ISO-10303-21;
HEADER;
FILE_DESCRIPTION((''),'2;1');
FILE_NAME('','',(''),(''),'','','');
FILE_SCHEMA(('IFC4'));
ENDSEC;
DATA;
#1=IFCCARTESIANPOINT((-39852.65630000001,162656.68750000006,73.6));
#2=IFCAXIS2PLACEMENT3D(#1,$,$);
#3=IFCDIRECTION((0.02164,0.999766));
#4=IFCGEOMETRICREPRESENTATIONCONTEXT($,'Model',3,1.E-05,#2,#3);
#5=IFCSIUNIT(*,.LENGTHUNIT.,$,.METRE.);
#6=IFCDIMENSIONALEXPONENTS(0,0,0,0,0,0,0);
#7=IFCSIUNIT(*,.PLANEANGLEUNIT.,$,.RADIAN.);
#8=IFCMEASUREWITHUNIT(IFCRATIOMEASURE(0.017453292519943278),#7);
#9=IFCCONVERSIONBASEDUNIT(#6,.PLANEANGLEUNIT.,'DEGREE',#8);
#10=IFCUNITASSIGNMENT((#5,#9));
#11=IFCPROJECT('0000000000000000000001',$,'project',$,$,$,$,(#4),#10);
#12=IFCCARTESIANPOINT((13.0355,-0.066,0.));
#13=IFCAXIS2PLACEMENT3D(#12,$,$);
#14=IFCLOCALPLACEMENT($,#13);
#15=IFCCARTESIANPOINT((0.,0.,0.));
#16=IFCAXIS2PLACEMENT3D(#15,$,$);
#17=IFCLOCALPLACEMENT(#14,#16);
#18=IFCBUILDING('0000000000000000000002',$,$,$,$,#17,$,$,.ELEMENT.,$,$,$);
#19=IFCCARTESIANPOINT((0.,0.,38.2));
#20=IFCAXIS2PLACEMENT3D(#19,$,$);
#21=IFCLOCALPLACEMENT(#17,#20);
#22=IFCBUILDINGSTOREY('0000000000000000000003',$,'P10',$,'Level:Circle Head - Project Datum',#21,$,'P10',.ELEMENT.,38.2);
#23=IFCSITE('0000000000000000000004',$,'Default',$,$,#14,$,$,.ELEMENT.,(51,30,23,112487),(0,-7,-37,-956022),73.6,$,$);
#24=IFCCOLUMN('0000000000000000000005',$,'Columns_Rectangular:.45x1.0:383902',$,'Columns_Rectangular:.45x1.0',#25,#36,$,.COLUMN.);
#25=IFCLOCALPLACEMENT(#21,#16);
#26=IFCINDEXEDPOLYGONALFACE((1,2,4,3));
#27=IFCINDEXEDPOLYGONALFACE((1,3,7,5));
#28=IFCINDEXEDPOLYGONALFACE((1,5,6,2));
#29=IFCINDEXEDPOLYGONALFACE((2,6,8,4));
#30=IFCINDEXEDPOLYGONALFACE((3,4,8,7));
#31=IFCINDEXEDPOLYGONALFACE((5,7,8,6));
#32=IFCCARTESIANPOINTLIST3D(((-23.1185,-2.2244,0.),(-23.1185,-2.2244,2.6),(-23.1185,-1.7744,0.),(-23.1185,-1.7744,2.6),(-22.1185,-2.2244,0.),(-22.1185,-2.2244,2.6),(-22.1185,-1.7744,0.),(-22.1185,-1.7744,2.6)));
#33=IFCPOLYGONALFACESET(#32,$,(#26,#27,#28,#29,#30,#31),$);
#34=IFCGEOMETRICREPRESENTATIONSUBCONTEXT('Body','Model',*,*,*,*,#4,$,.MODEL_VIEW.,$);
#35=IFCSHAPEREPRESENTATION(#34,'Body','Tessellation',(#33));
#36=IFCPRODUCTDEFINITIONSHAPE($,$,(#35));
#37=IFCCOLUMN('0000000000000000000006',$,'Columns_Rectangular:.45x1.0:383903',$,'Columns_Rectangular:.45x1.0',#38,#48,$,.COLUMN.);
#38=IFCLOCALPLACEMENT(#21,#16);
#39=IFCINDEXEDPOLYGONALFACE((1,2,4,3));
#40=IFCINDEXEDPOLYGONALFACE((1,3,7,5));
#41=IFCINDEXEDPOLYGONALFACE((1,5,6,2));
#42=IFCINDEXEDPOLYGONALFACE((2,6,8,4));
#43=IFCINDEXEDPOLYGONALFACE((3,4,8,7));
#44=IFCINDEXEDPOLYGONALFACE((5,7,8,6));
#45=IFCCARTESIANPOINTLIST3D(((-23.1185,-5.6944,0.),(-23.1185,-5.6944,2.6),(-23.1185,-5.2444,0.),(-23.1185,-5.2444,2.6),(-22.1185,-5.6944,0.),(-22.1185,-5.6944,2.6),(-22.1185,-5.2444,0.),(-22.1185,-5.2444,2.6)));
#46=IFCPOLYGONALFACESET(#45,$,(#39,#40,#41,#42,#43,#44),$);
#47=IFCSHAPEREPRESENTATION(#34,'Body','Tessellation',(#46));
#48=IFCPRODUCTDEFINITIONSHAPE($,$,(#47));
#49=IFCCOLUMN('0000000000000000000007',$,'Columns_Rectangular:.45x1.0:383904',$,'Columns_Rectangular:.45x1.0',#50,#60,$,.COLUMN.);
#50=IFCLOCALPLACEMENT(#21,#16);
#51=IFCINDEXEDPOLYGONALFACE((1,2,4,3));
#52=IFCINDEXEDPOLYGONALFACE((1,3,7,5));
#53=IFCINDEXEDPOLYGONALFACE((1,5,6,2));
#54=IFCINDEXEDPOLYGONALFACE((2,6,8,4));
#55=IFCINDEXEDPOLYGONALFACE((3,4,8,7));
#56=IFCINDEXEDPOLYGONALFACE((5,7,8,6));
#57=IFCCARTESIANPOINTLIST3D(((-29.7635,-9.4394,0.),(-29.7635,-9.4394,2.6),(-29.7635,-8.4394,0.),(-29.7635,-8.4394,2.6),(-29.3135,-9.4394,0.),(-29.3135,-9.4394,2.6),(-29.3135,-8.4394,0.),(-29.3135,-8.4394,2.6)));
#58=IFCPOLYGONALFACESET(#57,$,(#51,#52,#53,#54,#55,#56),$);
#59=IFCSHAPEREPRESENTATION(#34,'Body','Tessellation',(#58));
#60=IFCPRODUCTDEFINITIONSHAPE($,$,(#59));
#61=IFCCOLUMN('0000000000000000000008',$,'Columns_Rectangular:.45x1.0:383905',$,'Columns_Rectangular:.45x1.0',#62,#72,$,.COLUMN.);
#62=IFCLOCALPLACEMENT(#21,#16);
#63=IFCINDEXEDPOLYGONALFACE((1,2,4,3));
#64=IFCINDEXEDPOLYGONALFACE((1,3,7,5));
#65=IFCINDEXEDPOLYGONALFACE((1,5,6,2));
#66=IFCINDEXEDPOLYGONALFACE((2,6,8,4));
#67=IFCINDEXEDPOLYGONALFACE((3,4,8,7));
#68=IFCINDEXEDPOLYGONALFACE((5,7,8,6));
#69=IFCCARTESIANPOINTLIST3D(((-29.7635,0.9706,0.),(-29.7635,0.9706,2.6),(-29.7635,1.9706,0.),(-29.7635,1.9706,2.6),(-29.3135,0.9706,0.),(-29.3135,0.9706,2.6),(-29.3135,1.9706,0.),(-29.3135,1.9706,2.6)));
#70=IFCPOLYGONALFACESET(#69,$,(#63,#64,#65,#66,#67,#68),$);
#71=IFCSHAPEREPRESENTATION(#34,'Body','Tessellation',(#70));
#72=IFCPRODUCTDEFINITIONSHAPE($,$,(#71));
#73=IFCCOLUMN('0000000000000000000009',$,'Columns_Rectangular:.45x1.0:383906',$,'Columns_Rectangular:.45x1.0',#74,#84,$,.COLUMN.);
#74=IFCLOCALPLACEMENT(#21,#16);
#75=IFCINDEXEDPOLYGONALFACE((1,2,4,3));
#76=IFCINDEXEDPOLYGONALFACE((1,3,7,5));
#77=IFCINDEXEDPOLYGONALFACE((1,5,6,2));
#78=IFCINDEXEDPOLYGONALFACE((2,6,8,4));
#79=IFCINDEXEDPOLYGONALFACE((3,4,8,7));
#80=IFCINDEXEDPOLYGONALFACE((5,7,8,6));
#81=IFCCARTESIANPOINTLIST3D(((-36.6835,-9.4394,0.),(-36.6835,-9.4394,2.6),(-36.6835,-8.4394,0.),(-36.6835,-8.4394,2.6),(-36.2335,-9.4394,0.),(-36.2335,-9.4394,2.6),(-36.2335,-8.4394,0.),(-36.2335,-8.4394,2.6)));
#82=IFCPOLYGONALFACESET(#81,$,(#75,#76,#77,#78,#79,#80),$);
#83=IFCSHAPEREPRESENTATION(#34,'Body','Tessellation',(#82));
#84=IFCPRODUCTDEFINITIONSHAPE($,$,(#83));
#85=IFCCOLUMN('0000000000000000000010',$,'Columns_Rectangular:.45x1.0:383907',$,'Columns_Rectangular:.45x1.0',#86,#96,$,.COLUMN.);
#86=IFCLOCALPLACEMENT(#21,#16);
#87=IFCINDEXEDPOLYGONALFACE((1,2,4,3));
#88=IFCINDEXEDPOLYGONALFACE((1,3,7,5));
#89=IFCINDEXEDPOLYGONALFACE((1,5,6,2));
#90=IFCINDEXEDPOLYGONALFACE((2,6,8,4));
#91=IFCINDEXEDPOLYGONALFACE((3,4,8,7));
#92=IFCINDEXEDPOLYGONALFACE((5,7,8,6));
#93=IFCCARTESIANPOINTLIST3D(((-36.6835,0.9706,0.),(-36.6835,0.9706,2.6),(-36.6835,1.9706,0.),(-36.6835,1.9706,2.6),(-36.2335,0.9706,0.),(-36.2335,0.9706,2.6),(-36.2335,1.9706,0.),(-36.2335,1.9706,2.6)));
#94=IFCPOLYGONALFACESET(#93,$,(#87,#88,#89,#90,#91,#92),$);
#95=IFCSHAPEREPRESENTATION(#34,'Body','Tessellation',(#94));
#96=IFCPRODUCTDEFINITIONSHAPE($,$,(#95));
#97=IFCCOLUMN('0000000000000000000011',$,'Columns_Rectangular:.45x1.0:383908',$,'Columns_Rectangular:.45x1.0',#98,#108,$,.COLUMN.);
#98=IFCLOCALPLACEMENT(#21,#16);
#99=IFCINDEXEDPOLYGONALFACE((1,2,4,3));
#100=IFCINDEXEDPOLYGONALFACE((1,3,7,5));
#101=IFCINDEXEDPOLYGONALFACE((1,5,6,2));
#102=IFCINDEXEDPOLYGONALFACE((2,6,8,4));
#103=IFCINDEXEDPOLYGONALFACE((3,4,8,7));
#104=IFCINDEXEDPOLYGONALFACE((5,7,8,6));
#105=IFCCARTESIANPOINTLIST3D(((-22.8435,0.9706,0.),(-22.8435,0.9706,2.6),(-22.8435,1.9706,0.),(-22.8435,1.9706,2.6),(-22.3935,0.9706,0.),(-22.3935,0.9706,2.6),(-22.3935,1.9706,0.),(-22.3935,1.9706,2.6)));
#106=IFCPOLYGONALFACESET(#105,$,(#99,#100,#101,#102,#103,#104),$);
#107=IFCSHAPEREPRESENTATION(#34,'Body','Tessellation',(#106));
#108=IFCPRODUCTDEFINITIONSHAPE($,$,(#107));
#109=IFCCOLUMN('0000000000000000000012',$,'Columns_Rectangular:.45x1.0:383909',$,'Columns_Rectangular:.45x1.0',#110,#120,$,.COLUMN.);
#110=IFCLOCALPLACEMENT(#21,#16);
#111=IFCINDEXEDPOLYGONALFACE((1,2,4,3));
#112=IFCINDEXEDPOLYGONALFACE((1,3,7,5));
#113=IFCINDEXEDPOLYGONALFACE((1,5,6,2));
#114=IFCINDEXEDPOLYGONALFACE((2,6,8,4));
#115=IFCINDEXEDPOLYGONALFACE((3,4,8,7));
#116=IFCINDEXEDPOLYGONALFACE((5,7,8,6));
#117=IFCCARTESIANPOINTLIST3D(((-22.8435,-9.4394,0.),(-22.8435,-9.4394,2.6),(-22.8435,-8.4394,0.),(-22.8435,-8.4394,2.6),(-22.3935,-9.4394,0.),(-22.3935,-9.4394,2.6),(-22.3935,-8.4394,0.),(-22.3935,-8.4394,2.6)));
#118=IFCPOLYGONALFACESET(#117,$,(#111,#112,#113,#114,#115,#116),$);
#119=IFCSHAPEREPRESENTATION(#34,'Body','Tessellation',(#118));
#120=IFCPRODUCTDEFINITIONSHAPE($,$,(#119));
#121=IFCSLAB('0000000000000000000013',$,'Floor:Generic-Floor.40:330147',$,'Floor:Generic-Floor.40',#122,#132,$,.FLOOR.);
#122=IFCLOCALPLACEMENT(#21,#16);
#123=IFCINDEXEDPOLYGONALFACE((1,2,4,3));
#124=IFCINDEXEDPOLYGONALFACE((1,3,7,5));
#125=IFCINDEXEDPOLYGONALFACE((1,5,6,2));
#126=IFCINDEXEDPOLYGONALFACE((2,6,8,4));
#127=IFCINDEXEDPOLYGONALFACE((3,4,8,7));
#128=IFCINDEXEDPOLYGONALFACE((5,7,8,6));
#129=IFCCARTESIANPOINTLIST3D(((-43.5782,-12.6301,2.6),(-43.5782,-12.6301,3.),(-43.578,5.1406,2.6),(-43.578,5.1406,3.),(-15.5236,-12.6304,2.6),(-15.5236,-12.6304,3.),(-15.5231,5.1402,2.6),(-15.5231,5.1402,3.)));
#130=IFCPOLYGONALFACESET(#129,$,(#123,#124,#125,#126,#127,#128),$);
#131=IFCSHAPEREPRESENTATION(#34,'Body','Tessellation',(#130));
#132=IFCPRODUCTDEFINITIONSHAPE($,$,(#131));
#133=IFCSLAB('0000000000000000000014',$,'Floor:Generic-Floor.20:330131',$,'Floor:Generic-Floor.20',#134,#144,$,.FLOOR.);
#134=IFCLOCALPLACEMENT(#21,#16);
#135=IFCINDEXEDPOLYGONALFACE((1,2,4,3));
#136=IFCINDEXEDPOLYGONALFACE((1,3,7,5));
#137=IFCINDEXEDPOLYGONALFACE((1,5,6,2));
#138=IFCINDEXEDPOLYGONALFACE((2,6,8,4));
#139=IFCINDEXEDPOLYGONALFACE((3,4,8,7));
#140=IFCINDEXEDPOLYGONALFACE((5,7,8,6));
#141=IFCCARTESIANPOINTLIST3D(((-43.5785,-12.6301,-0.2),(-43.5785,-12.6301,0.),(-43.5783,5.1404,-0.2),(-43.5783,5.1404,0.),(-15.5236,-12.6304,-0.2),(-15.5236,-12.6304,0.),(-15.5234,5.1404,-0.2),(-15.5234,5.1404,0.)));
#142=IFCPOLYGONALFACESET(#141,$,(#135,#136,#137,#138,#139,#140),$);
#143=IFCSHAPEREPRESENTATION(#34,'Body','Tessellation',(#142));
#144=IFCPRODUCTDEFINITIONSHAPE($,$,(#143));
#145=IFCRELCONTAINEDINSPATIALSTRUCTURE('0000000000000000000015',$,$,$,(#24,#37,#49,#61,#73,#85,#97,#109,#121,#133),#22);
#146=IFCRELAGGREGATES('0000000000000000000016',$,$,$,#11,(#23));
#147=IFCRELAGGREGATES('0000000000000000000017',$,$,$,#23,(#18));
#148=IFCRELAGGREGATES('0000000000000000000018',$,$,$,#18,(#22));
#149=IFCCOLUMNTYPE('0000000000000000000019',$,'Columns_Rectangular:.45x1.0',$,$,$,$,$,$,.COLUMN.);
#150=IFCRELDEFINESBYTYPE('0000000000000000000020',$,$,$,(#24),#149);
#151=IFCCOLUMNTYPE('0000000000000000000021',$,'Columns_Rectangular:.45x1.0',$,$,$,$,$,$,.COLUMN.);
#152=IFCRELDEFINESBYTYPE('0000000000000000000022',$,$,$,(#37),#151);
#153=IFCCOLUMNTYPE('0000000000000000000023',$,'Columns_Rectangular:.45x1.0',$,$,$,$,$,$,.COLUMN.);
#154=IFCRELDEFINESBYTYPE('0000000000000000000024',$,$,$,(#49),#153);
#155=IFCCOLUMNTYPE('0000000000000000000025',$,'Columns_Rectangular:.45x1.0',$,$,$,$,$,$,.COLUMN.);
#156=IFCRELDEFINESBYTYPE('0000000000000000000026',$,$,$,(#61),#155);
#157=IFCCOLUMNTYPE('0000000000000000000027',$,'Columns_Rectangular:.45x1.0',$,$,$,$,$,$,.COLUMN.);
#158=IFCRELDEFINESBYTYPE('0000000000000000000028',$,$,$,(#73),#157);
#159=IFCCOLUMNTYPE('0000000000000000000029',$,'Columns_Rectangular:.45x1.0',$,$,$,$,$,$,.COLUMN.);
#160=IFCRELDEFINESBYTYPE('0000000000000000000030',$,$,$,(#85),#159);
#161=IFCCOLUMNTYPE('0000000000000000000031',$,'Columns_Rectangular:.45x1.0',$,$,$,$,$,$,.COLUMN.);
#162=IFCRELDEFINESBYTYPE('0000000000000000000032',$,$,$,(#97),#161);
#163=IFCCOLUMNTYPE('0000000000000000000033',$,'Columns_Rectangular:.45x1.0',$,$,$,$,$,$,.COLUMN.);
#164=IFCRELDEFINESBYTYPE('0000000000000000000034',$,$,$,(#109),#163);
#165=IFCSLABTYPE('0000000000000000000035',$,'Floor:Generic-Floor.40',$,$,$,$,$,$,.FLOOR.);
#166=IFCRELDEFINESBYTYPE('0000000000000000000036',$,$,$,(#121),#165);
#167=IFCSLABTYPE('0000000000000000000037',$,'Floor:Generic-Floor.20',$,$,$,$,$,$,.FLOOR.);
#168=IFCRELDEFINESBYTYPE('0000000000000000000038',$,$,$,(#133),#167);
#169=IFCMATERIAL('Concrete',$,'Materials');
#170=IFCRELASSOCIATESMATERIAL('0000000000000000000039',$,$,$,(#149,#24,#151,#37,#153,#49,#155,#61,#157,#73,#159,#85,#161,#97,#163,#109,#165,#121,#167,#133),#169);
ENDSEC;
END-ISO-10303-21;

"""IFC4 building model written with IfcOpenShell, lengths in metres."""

from ifc_helpers import new_model, entity, si_unit, converted_unit, direction, frame, origin, place, context, subcontext, project, spatial, indexed_curve, outline, extrude, source, transform, mapped, material, type_object, type_shapes, element, save


model = new_model("IFC4")

# Units and contexts
model_context = context("Model", 3, precision=1e-05, world=frame((-39852.65630000001, 162656.68750000006, 73.6)), true_north=direction((0.02164, 0.999766)))
body_context = subcontext(model_context, "Body", "Model", "MODEL_VIEW")
ifc_project = project(units=[si_unit("LENGTHUNIT", "METRE"), converted_unit("PLANEANGLEUNIT", "DEGREE", entity("IfcRatioMeasure", 0.017453292519943278), si_unit("PLANEANGLEUNIT", "RADIAN"), dimensions=[0, 0, 0, 0, 0, 0, 0])], contexts=[model_context])

# Site, building, storey
site_placement = place(None, frame((13.0355, -0.066, 0.0)))
site = spatial("IfcSite", under=ifc_project, at=site_placement, Name="Default", CompositionType="ELEMENT", RefLatitude=(51, 30, 23, 112487), RefLongitude=(0, -7, -37, -956022), RefElevation=73.6)
building_placement = place(site_placement, origin())
building = spatial("IfcBuilding", under=site, at=building_placement, CompositionType="ELEMENT")
storey_placement = place(building_placement, frame((0.0, 0.0, 38.2)))
storey = spatial("IfcBuildingStorey", under=building, at=storey_placement, Name="P10", ObjectType="Level:Circle Head - Project Datum", LongName="P10", CompositionType="ELEMENT", Elevation=38.2)

# Columns
ifc_material = material(Name="Concrete", Category="Materials")
column_type_1 = type_object("IfcColumnType", Name="Columns_Rectangular:.45x1.0", PredefinedType="COLUMN", material=ifc_material)
shared_shape_1 = source(origin(), body_context, "Body", "SweptSolid", [
    extrude(outline(indexed_curve([(-0.225, -0.5), (0.225, -0.5), (0.225, 0.5), (-0.225, 0.5), (-0.225, -0.5)], self_intersect=False)), frame((-22.6185, -1.9994, 38.2), z_axis=(0.0, 0.0, 1.0), x_axis=(0.0, -1.0, 0.0)), (0.0, 0.0, 1.0), 2.6),
])
type_shapes(column_type_1, [shared_shape_1])
column_1_placement = place(storey_placement, frame((0.0, 0.0, -38.2)))
element("IfcColumn", 1, at=column_1_placement, inside=storey, type_object=column_type_1, material=ifc_material, Name="Columns_Rectangular:.45x1.0:383902", ObjectType="Columns_Rectangular:.45x1.0", PredefinedType="COLUMN", context=body_context, shape_type="MappedRepresentation", body=[
    mapped(shared_shape_1, transform((0.0, 0.0, 0.0), scale=1.0)),
])
column_type_2 = type_object("IfcColumnType", Name="Columns_Rectangular:.45x1.0", PredefinedType="COLUMN", material=ifc_material)
shared_shape_2 = source(origin(), body_context, "Body", "SweptSolid", [
    extrude(outline(indexed_curve([(-0.225, -0.5), (0.225, -0.5), (0.225, 0.5), (-0.225, 0.5), (-0.225, -0.5)], self_intersect=False)), frame((-22.6185, -5.4694, 38.2), z_axis=(0.0, 0.0, 1.0), x_axis=(0.0, -1.0, 0.0)), (0.0, 0.0, 1.0), 2.6),
])
type_shapes(column_type_2, [shared_shape_2])
column_2_placement = place(storey_placement, frame((0.0, 0.0, -38.2)))
element("IfcColumn", 2, at=column_2_placement, inside=storey, type_object=column_type_2, material=ifc_material, Name="Columns_Rectangular:.45x1.0:383903", ObjectType="Columns_Rectangular:.45x1.0", PredefinedType="COLUMN", context=body_context, shape_type="MappedRepresentation", body=[
    mapped(shared_shape_2, transform((0.0, 0.0, 0.0), scale=1.0)),
])
column_type_3 = type_object("IfcColumnType", Name="Columns_Rectangular:.45x1.0", PredefinedType="COLUMN", material=ifc_material)
shared_shape_3 = source(origin(), body_context, "Body", "SweptSolid", [
    extrude(outline(indexed_curve([(-0.5, -0.225), (0.5, -0.225), (0.5, 0.225), (-0.5, 0.225), (-0.5, -0.225)], self_intersect=False)), frame((-29.5385, -8.9394, 38.2), z_axis=(0.0, 0.0, 1.0), x_axis=(0.0, -1.0, 0.0)), (0.0, 0.0, 1.0), 2.6),
])
type_shapes(column_type_3, [shared_shape_3])
column_3_placement = place(storey_placement, frame((0.0, 0.0, -38.2)))
element("IfcColumn", 3, at=column_3_placement, inside=storey, type_object=column_type_3, material=ifc_material, Name="Columns_Rectangular:.45x1.0:383904", ObjectType="Columns_Rectangular:.45x1.0", PredefinedType="COLUMN", context=body_context, shape_type="MappedRepresentation", body=[
    mapped(shared_shape_3, transform((0.0, 0.0, 0.0), scale=1.0)),
])
column_type_4 = type_object("IfcColumnType", Name="Columns_Rectangular:.45x1.0", PredefinedType="COLUMN", material=ifc_material)
shared_shape_4 = source(origin(), body_context, "Body", "SweptSolid", [
    extrude(outline(indexed_curve([(-0.5, -0.225), (0.5, -0.225), (0.5, 0.225), (-0.5, 0.225), (-0.5, -0.225)], self_intersect=False)), frame((-29.5385, 1.4706, 38.2), z_axis=(0.0, 0.0, 1.0), x_axis=(0.0, -1.0, 0.0)), (0.0, 0.0, 1.0), 2.6),
])
type_shapes(column_type_4, [shared_shape_4])
column_4_placement = place(storey_placement, frame((0.0, 0.0, -38.2)))
element("IfcColumn", 4, at=column_4_placement, inside=storey, type_object=column_type_4, material=ifc_material, Name="Columns_Rectangular:.45x1.0:383905", ObjectType="Columns_Rectangular:.45x1.0", PredefinedType="COLUMN", context=body_context, shape_type="MappedRepresentation", body=[
    mapped(shared_shape_4, transform((0.0, 0.0, 0.0), scale=1.0)),
])
column_type_5 = type_object("IfcColumnType", Name="Columns_Rectangular:.45x1.0", PredefinedType="COLUMN", material=ifc_material)
shared_shape_5 = source(origin(), body_context, "Body", "SweptSolid", [
    extrude(outline(indexed_curve([(-0.5, -0.225), (0.5, -0.225), (0.5, 0.225), (-0.5, 0.225), (-0.5, -0.225)], self_intersect=False)), frame((-36.4585, -8.9394, 38.2), z_axis=(0.0, 0.0, 1.0), x_axis=(0.0, -1.0, 0.0)), (0.0, 0.0, 1.0), 2.6),
])
type_shapes(column_type_5, [shared_shape_5])
column_5_placement = place(storey_placement, frame((0.0, 0.0, -38.2)))
element("IfcColumn", 5, at=column_5_placement, inside=storey, type_object=column_type_5, material=ifc_material, Name="Columns_Rectangular:.45x1.0:383906", ObjectType="Columns_Rectangular:.45x1.0", PredefinedType="COLUMN", context=body_context, shape_type="MappedRepresentation", body=[
    mapped(shared_shape_5, transform((0.0, 0.0, 0.0), scale=1.0)),
])
column_type_6 = type_object("IfcColumnType", Name="Columns_Rectangular:.45x1.0", PredefinedType="COLUMN", material=ifc_material)
shared_shape_6 = source(origin(), body_context, "Body", "SweptSolid", [
    extrude(outline(indexed_curve([(-0.5, -0.225), (0.5, -0.225), (0.5, 0.225), (-0.5, 0.225), (-0.5, -0.225)], self_intersect=False)), frame((-36.4585, 1.4706, 38.2), z_axis=(0.0, 0.0, 1.0), x_axis=(0.0, -1.0, 0.0)), (0.0, 0.0, 1.0), 2.6),
])
type_shapes(column_type_6, [shared_shape_6])
column_6_placement = place(storey_placement, frame((0.0, 0.0, -38.2)))
element("IfcColumn", 6, at=column_6_placement, inside=storey, type_object=column_type_6, material=ifc_material, Name="Columns_Rectangular:.45x1.0:383907", ObjectType="Columns_Rectangular:.45x1.0", PredefinedType="COLUMN", context=body_context, shape_type="MappedRepresentation", body=[
    mapped(shared_shape_6, transform((0.0, 0.0, 0.0), scale=1.0)),
])
column_type_7 = type_object("IfcColumnType", Name="Columns_Rectangular:.45x1.0", PredefinedType="COLUMN", material=ifc_material)
shared_shape_7 = source(origin(), body_context, "Body", "SweptSolid", [
    extrude(outline(indexed_curve([(-0.5, -0.225), (0.5, -0.225), (0.5, 0.225), (-0.5, 0.225), (-0.5, -0.225)], self_intersect=False)), frame((-22.6185, 1.4706, 38.2), z_axis=(0.0, 0.0, 1.0), x_axis=(0.0, -1.0, 0.0)), (0.0, 0.0, 1.0), 2.6),
])
type_shapes(column_type_7, [shared_shape_7])
column_7_placement = place(storey_placement, frame((0.0, 0.0, -38.2)))
element("IfcColumn", 7, at=column_7_placement, inside=storey, type_object=column_type_7, material=ifc_material, Name="Columns_Rectangular:.45x1.0:383908", ObjectType="Columns_Rectangular:.45x1.0", PredefinedType="COLUMN", context=body_context, shape_type="MappedRepresentation", body=[
    mapped(shared_shape_7, transform((0.0, 0.0, 0.0), scale=1.0)),
])
column_type_8 = type_object("IfcColumnType", Name="Columns_Rectangular:.45x1.0", PredefinedType="COLUMN", material=ifc_material)
shared_shape_8 = source(origin(), body_context, "Body", "SweptSolid", [
    extrude(outline(indexed_curve([(-0.5, -0.225), (0.5, -0.225), (0.5, 0.225), (-0.5, 0.225), (-0.5, -0.225)], self_intersect=False)), frame((-22.6185, -8.9394, 38.2), z_axis=(0.0, 0.0, 1.0), x_axis=(0.0, -1.0, 0.0)), (0.0, 0.0, 1.0), 2.6),
])
type_shapes(column_type_8, [shared_shape_8])
column_8_placement = place(storey_placement, frame((0.0, 0.0, -38.2)))
element("IfcColumn", 8, at=column_8_placement, inside=storey, type_object=column_type_8, material=ifc_material, Name="Columns_Rectangular:.45x1.0:383909", ObjectType="Columns_Rectangular:.45x1.0", PredefinedType="COLUMN", context=body_context, shape_type="MappedRepresentation", body=[
    mapped(shared_shape_8, transform((0.0, 0.0, 0.0), scale=1.0)),
])

# Slabs
slab_type_1 = type_object("IfcSlabType", Name="Floor:Generic-Floor.40", PredefinedType="FLOOR", material=ifc_material)
slab_1_placement = place(storey_placement, origin())
element("IfcSlab", 9, at=slab_1_placement, inside=storey, type_object=slab_type_1, material=ifc_material, Name="Floor:Generic-Floor.40:330147", ObjectType="Floor:Generic-Floor.40", PredefinedType="FLOOR", context=body_context, shape_type="SweptSolid", body=[
    extrude(outline(indexed_curve([(-14.0274, -8.8853), (14.0275, -8.8853), (14.0273, 8.8853), (-14.0273, 8.8854), (-14.0274, -8.8853)], self_intersect=False)), frame((-29.5507, -3.7449, 3.0), z_axis=(0.0, 0.0, -1.0), x_axis=(1.0, -0.000016, 0.0)), (0.0, 0.0, 1.0), 0.4),
])
slab_type_2 = type_object("IfcSlabType", Name="Floor:Generic-Floor.20", PredefinedType="FLOOR", material=ifc_material)
slab_2_placement = place(storey_placement, origin())
element("IfcSlab", 10, at=slab_2_placement, inside=storey, type_object=slab_type_2, material=ifc_material, Name="Floor:Generic-Floor.20:330131", ObjectType="Floor:Generic-Floor.20", PredefinedType="FLOOR", context=body_context, shape_type="SweptSolid", body=[
    extrude(outline(indexed_curve([(-14.0274, -8.8853), (14.0275, -8.8853), (14.0274, 8.8855), (-14.0275, 8.8852), (-14.0274, -8.8853)], self_intersect=False)), frame((-29.5509, -3.7449, 0.0), z_axis=(0.0, 0.0, -1.0), x_axis=(1.0, 0.0, 0.0)), (0.0, 0.0, 1.0), 0.2),
])

save(model, "model.ifc")
